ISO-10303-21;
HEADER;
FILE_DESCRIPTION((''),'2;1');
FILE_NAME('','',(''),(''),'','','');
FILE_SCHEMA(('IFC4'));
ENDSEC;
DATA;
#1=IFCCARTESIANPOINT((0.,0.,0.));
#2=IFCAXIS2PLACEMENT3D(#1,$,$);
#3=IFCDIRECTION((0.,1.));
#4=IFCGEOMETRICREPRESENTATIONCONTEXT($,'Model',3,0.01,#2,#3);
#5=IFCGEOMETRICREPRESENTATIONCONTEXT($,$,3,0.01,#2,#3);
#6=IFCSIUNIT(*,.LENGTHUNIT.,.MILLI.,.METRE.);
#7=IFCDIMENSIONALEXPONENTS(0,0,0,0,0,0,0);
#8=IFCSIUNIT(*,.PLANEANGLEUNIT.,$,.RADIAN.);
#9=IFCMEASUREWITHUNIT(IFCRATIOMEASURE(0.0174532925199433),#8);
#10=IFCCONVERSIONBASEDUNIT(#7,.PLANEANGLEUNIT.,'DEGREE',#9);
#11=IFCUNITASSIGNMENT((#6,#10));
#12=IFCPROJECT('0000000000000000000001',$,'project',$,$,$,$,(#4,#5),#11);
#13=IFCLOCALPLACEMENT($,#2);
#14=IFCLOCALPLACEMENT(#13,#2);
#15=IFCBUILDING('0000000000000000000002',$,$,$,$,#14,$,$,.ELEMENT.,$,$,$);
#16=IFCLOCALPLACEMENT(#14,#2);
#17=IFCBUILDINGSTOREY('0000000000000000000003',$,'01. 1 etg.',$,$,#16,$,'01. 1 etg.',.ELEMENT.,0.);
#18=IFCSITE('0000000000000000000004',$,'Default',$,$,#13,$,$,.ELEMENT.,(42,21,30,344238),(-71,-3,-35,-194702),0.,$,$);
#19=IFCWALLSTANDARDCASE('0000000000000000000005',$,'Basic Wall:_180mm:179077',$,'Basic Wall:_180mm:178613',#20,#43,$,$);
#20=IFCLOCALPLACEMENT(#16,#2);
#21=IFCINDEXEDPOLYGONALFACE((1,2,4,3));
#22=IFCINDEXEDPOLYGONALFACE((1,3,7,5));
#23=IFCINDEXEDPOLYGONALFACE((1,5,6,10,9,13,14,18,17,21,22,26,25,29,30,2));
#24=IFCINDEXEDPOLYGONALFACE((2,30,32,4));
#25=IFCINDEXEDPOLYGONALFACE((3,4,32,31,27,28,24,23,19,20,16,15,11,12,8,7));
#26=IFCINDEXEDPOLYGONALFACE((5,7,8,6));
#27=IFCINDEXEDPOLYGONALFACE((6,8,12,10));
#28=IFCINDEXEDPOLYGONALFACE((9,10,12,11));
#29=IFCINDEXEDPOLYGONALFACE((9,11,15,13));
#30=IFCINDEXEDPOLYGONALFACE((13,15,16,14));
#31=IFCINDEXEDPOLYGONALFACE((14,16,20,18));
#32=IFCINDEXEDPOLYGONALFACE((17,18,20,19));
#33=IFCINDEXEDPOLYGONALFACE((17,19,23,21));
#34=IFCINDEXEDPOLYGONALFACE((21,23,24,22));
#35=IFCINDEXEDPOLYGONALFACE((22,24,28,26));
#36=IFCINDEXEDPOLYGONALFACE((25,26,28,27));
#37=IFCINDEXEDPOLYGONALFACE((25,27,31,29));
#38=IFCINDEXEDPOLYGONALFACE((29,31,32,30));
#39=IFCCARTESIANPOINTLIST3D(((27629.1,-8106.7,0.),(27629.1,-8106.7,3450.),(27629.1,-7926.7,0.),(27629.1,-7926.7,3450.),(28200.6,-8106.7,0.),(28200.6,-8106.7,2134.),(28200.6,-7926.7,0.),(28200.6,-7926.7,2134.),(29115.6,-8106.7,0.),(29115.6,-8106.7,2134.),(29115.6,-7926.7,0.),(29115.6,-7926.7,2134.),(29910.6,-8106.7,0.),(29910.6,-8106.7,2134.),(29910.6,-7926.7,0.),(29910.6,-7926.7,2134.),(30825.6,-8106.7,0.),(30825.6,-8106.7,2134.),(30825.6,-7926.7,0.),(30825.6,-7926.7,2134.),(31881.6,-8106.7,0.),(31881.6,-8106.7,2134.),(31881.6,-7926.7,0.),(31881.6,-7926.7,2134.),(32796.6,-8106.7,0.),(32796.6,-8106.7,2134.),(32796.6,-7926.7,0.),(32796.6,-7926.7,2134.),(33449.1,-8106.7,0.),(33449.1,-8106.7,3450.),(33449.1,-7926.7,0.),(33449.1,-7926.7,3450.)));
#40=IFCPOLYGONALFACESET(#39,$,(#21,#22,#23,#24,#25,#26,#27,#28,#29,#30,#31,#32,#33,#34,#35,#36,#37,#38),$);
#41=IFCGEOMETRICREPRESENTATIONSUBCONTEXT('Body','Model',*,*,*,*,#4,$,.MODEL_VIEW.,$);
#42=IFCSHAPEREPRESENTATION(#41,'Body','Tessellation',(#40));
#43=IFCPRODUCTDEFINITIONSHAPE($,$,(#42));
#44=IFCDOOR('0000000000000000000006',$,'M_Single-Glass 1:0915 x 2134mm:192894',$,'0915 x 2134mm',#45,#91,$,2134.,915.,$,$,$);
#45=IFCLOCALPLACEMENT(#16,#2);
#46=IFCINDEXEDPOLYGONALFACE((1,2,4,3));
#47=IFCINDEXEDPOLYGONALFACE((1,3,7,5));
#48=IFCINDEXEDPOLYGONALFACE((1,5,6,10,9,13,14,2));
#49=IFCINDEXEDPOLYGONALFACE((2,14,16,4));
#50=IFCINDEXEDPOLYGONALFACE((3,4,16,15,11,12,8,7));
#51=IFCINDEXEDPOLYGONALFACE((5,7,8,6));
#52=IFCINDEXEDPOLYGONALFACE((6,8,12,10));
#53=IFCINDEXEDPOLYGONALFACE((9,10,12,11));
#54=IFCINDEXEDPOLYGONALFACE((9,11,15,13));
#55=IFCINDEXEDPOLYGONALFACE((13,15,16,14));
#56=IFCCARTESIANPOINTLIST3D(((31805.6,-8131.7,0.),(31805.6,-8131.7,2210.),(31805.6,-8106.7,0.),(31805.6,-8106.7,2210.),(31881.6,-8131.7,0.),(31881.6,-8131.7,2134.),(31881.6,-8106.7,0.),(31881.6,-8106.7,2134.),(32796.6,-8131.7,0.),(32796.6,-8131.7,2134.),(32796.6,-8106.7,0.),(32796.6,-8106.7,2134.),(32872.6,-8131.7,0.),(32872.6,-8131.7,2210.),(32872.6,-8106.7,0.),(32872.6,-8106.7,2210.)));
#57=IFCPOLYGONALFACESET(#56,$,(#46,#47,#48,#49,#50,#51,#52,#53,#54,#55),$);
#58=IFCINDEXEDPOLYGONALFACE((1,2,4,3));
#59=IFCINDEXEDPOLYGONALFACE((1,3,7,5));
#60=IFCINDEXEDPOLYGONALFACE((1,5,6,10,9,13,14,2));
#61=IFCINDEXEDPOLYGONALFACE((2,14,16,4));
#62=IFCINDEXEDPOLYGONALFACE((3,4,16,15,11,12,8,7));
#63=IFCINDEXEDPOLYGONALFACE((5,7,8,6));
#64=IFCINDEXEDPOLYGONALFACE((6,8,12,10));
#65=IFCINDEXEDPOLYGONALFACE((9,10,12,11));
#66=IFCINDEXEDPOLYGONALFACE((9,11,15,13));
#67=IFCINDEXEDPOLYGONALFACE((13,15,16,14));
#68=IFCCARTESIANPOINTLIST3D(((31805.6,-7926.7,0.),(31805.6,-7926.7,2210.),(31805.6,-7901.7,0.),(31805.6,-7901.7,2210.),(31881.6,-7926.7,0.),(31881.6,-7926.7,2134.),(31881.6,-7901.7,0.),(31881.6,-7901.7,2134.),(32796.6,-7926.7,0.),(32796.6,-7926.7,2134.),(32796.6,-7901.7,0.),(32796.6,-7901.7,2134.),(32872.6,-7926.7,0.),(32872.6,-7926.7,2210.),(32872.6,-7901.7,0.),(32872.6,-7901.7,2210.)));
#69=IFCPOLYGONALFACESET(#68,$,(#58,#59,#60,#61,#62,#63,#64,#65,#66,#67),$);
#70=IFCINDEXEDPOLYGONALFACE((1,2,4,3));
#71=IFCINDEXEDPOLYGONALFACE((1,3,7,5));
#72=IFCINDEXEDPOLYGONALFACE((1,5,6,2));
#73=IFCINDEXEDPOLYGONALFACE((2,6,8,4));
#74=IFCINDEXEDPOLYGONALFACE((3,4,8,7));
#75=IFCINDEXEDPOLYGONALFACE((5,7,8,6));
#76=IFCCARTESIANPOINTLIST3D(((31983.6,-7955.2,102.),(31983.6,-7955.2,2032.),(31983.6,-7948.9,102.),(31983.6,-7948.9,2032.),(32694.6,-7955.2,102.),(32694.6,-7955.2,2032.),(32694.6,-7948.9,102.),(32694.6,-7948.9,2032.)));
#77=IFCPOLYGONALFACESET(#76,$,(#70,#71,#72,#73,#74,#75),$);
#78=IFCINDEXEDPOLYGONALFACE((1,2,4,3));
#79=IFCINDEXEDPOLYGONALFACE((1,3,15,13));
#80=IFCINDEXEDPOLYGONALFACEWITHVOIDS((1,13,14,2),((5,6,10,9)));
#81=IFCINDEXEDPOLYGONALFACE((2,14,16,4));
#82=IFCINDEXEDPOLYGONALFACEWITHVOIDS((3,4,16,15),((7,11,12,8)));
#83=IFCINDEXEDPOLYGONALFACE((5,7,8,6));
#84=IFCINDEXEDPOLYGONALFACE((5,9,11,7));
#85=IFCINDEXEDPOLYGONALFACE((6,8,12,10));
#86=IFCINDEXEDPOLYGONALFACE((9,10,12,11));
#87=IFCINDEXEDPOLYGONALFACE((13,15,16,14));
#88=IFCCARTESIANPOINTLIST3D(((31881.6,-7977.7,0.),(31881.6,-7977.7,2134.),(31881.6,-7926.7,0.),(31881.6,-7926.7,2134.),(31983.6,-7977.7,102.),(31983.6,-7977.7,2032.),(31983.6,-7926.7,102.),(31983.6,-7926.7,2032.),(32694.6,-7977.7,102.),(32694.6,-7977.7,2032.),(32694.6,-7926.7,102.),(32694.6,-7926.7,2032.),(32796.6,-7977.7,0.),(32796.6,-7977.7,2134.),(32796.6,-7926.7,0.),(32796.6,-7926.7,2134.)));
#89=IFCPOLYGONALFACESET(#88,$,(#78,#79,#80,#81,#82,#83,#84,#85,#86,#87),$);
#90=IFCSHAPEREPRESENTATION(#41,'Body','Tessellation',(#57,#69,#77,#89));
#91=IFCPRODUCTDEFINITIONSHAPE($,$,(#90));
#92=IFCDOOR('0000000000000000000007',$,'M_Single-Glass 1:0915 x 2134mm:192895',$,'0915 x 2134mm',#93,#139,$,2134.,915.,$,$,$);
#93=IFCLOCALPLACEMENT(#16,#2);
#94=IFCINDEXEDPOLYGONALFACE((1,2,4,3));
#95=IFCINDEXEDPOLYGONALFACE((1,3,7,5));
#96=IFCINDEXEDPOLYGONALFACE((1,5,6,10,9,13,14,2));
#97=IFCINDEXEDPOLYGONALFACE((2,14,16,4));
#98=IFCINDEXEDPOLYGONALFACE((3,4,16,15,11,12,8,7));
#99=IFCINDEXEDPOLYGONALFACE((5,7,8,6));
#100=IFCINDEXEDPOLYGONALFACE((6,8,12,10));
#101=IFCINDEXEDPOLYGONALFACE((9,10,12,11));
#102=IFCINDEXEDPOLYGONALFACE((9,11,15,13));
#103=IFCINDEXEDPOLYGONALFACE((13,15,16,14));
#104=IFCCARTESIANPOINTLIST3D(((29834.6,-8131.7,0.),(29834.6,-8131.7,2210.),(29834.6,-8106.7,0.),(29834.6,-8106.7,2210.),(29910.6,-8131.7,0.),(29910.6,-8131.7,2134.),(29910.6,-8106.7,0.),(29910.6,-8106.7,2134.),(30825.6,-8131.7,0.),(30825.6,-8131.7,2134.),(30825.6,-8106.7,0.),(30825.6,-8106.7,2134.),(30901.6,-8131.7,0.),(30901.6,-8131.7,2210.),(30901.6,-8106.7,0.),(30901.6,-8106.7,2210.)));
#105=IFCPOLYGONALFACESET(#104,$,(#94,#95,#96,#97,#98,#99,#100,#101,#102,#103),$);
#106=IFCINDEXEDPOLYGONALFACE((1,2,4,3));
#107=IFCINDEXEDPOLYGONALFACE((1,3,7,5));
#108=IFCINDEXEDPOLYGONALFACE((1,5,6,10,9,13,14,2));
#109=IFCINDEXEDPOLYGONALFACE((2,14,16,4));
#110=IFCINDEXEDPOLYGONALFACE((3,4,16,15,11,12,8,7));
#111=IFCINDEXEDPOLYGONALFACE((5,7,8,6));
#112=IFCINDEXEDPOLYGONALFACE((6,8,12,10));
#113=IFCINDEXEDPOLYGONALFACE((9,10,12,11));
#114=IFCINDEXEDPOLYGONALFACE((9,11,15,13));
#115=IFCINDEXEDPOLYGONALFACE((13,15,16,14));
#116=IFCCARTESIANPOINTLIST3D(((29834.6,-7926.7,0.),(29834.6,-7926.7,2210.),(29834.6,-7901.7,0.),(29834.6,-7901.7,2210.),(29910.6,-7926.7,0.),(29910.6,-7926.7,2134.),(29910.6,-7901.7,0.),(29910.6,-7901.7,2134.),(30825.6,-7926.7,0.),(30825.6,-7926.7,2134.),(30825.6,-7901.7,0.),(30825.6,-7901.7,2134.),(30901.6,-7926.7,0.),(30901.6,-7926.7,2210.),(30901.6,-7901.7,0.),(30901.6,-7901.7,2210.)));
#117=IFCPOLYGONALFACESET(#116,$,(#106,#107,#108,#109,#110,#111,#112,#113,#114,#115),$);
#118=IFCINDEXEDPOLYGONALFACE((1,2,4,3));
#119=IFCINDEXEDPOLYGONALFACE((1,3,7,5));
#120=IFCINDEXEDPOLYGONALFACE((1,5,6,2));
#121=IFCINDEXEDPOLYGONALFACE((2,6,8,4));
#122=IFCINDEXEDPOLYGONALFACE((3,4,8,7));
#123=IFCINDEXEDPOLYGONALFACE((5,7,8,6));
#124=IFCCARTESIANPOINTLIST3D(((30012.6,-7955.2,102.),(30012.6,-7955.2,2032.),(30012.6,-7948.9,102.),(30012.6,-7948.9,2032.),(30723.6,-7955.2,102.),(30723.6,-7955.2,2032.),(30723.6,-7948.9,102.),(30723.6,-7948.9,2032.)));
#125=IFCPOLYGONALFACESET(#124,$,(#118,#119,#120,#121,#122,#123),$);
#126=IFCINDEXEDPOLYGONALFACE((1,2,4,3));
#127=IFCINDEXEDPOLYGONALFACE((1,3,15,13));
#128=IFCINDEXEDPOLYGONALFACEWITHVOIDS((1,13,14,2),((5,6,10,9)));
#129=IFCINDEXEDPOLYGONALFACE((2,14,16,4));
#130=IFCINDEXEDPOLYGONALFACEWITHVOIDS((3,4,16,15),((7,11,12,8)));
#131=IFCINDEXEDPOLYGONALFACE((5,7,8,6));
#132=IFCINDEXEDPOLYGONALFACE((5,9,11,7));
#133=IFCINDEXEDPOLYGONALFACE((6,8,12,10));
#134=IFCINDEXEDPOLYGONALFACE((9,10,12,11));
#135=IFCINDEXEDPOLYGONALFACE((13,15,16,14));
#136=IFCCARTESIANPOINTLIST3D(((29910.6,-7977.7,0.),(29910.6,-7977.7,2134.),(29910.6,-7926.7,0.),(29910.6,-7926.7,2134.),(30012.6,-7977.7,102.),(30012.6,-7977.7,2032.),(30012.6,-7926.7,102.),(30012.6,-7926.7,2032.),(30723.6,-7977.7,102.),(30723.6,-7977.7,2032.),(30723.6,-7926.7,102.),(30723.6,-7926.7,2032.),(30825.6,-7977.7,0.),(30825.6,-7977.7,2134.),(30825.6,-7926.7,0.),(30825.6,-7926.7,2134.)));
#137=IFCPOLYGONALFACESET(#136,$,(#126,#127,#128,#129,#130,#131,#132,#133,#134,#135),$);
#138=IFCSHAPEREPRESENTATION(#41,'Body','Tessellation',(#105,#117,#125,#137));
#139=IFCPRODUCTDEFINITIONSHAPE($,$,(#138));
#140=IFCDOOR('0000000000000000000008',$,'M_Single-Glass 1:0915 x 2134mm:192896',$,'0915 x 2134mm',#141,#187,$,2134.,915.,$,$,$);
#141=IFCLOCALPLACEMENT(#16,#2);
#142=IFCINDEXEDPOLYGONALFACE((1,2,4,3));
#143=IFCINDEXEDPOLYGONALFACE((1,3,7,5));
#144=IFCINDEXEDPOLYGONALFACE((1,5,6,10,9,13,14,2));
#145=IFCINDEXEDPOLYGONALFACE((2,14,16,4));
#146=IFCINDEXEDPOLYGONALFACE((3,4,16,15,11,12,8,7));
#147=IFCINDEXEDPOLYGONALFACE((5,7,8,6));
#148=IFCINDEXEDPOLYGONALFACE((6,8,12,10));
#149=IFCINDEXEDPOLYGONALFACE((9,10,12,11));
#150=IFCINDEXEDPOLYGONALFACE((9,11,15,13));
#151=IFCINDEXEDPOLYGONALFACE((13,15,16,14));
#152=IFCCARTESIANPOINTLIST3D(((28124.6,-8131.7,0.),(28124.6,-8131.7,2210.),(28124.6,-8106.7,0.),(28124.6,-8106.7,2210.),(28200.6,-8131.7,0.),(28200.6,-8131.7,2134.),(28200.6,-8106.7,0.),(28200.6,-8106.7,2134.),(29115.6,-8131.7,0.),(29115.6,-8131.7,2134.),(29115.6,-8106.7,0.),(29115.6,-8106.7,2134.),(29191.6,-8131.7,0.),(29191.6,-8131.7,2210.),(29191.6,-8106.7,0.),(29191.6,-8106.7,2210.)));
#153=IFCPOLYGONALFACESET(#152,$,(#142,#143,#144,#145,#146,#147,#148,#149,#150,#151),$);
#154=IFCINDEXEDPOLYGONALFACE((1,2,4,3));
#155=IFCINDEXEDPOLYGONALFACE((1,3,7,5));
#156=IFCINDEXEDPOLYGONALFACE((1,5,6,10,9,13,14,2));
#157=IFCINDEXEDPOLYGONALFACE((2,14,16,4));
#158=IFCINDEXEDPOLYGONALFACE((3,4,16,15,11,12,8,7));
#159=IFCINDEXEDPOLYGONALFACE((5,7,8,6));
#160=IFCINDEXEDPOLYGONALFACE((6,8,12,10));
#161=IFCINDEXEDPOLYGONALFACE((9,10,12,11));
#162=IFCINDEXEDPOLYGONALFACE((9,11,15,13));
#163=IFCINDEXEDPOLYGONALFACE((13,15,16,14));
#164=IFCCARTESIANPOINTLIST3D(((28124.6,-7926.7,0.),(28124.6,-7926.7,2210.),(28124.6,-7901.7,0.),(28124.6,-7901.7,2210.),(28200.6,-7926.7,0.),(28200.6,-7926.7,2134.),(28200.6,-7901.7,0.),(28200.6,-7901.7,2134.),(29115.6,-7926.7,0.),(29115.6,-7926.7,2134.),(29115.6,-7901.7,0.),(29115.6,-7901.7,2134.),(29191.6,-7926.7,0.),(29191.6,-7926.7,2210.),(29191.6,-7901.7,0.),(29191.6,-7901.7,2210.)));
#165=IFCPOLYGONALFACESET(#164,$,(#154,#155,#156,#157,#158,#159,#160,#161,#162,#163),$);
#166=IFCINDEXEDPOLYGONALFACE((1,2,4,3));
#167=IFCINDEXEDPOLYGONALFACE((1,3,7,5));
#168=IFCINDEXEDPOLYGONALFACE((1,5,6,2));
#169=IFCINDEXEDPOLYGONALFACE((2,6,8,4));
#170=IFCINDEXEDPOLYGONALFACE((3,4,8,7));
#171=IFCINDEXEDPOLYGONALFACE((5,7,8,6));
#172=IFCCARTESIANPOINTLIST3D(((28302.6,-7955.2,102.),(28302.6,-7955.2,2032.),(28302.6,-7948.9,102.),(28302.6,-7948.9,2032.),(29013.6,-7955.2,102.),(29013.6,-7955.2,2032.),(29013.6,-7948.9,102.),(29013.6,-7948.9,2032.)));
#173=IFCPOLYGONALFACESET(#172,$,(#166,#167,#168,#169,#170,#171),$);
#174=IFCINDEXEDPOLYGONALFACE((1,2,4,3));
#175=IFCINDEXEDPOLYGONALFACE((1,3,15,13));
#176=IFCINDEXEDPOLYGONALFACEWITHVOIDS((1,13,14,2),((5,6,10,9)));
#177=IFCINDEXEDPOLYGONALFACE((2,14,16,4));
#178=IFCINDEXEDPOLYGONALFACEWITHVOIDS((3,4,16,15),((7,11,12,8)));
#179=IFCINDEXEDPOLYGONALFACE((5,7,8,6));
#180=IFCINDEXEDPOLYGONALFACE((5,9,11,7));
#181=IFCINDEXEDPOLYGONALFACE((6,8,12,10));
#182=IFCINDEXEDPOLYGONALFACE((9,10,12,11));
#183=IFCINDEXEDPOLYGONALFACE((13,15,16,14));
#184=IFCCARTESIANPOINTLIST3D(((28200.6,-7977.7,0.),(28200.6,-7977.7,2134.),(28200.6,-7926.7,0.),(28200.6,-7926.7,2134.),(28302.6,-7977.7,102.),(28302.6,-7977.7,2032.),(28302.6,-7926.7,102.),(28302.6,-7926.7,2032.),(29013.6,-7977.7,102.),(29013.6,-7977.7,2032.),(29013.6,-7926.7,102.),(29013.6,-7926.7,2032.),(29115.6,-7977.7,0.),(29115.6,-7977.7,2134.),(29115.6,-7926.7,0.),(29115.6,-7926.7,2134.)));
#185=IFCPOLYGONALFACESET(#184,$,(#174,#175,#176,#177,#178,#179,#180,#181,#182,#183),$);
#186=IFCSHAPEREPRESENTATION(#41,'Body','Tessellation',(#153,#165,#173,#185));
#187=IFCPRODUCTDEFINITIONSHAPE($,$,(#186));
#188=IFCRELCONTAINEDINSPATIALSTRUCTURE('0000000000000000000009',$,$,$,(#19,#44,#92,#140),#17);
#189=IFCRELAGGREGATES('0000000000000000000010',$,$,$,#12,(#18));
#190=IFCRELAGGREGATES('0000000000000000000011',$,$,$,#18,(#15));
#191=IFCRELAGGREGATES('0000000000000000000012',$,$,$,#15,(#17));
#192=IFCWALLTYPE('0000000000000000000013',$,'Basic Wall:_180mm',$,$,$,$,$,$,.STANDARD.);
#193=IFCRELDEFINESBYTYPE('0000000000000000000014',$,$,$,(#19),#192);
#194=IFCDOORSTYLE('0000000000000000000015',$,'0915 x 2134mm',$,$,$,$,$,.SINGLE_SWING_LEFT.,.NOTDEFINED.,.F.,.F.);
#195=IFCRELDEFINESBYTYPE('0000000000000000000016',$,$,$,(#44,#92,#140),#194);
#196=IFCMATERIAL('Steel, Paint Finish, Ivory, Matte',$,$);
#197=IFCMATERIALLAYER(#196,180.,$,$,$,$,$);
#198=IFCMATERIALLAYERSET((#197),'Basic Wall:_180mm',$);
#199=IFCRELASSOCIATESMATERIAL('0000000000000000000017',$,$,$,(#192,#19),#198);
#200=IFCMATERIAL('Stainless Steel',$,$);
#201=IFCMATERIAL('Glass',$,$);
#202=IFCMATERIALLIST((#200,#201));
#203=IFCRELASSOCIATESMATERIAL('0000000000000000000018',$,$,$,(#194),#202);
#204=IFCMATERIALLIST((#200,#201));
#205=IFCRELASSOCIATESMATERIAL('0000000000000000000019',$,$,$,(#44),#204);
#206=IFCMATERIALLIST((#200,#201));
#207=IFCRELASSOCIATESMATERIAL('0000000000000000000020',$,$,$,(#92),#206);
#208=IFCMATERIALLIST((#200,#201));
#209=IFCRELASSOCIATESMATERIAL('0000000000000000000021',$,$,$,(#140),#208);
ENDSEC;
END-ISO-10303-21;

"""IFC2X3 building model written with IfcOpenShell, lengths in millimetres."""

from ifc_helpers import new_model, entity, si_unit, converted_unit, direction, frame, frame_2d, origin, place, context, subcontext, project, spatial, polyline, rectangle, outline, extrude, clip, bounded_halfspace, source, transform, mapped, material, material_list, layer, layer_set, layer_usage, type_object, type_shapes, element, fill, save


model = new_model("IFC2X3")

# Units and contexts
model_context = context("Model", 3, precision=0.01, world=origin(), true_north=direction((0.0, 1.0)))
context_of_model = context(None, 3, precision=0.01, world=origin(), true_north=direction((0.0, 1.0)))
body_context = subcontext(model_context, "Body", "Model", "MODEL_VIEW")
ifc_project = project(units=[si_unit("LENGTHUNIT", "METRE", prefix="MILLI"), converted_unit("PLANEANGLEUNIT", "DEGREE", entity("IfcRatioMeasure", 0.0174532925199433), si_unit("PLANEANGLEUNIT", "RADIAN"), dimensions=[0, 0, 0, 0, 0, 0, 0])], contexts=[model_context, context_of_model])

# Site, building, storey
site_placement = place(None, origin())
site = spatial("IfcSite", under=ifc_project, at=site_placement, Name="Default", CompositionType="ELEMENT", RefLatitude=(42, 21, 30, 344238), RefLongitude=(-71, -3, -35, -194702), RefElevation=0.0)
building_placement = place(site_placement, origin())
building = spatial("IfcBuilding", under=site, at=building_placement, CompositionType="ELEMENT")
storey_placement = place(building_placement, origin())
storey = spatial("IfcBuildingStorey", under=building, at=storey_placement, Name="01. 1 etg.", LongName="01. 1 etg.", CompositionType="ELEMENT", Elevation=0.0)

# Shared definitions
ifc_material_1 = material(Name="Steel, Paint Finish, Ivory, Matte")
ifc_material_2 = material(Name="Stainless Steel")
ifc_material_3 = material(Name="Glass")

# Shared definitions
ifc_layer_1 = layer(ifc_material_1, 180.0)
ifc_layer_set_1 = layer_set([ifc_layer_1], Name="Basic Wall:_180mm")
wall_type_1 = type_object("IfcWallType", Name="Basic Wall:_180mm", PredefinedType="STANDARD", material=ifc_layer_set_1)

# Wall, openings, doors
ifc_layer_usage_1 = layer_usage(ifc_layer_set_1, "AXIS2", "POSITIVE", -90.0)
wall_1_placement = place(storey_placement, frame((27629.1, -8016.7, 0.0)))
wall_1 = element("IfcWallStandardCase", 1, at=wall_1_placement, inside=storey, type_object=wall_type_1, material=ifc_layer_usage_1, Name="Basic Wall:_180mm:179077", ObjectType="Basic Wall:_180mm:178613", context=body_context, shape_type="Clipping", body=[
    clip(extrude(rectangle(XDim=5820.0, YDim=180.0, at=frame_2d((2910.0, 0.0), x_axis=(-1.0, 0.0))), origin(), (0.0, 0.0, 1.0), 3450.0), bounded_halfspace(frame((0.0, -90.0, 3450.0), z_axis=(0.0, 0.0, -1.0), x_axis=(0.0, -1.0, 0.0)), True, frame((0.0, -90.0, 3450.0)), polyline([(0.0, 0.0), (5820.0, 0.0), (5820.0, 180.0), (3600.0, 180.0), (3500.0, 180.0), (1978.0, 180.0), (1878.0, 180.0), (180.0, 180.0), (0.0, 180.0), (0.0, 0.0)]))),
])
opening_1_placement = place(wall_1_placement, frame((4252.5, -90.0, 0.0)))
opening_1 = element("IfcOpeningElement", 2, at=opening_1_placement, cuts=wall_1, ObjectType="Opening", context=body_context, shape_type="SweptSolid", body=[
    extrude(rectangle(XDim=915.0, YDim=2134.0, at=frame_2d((1067.0, 457.5), x_axis=(0.0, -1.0))), frame((0.0, 0.0, 0.0), z_axis=(0.0, 1.0, 0.0), x_axis=(0.0, 0.0, 1.0)), (0.0, 0.0, 1.0), 180.0),
])
opening_2_placement = place(wall_1_placement, frame((2281.5, -90.0, 0.0)))
opening_2 = element("IfcOpeningElement", 3, at=opening_2_placement, cuts=wall_1, ObjectType="Opening", context=body_context, shape_type="SweptSolid", body=[
    extrude(rectangle(XDim=915.0, YDim=2134.0, at=frame_2d((1067.0, 457.5), x_axis=(0.0, -1.0))), frame((0.0, 0.0, 0.0), z_axis=(0.0, 1.0, 0.0), x_axis=(0.0, 0.0, 1.0)), (0.0, 0.0, 1.0), 180.0),
])
opening_3_placement = place(wall_1_placement, frame((571.5, -90.0, 0.0)))
opening_3 = element("IfcOpeningElement", 4, at=opening_3_placement, cuts=wall_1, ObjectType="Opening", context=body_context, shape_type="SweptSolid", body=[
    extrude(rectangle(XDim=915.0, YDim=2134.0, at=frame_2d((1067.0, 457.5), x_axis=(0.0, -1.0))), frame((0.0, 0.0, 0.0), z_axis=(0.0, 1.0, 0.0), x_axis=(0.0, 0.0, 1.0)), (0.0, 0.0, 1.0), 180.0),
])
ifc_material_list_1 = material_list([ifc_material_2, ifc_material_3])
ifc_material_list_2 = material_list([ifc_material_2, ifc_material_3])
door_style_1 = type_object("IfcDoorStyle", Name="0915 x 2134mm", ConstructionType="NOTDEFINED", OperationType="SINGLE_SWING_LEFT", ParameterTakesPrecedence=False, Sizeable=False, material=ifc_material_list_2)
shared_shape_1 = source(origin(), body_context, "Body", "SweptSolid", [
    extrude(outline(polyline([(-457.5, -1048.0), (-457.5, 1086.0), (-533.5, 1086.0), (-533.5, -1124.0), (533.5, -1124.0), (533.5, 1086.0), (457.5, 1086.0), (457.5, -1048.0), (-457.5, -1048.0)])), frame((457.5, 0.0, 1086.0), z_axis=(0.0, 1.0, 0.0), x_axis=(1.0, 0.0, 0.0)), (0.0, 0.0, -1.0), 25.0),
    extrude(outline(polyline([(-457.5, -1048.0), (-457.5, 1086.0), (-533.5, 1086.0), (-533.5, -1124.0), (533.5, -1124.0), (533.5, 1086.0), (457.5, 1086.0), (457.5, -1048.0), (-457.5, -1048.0)])), frame((457.5, 205.0, 1086.0), z_axis=(0.0, 1.0, 0.0), x_axis=(1.0, 0.0, 0.0)), (0.0, 0.0, -1.0), 25.0),
    extrude(rectangle(XDim=711.0, YDim=6.3, at=frame_2d((0.0, 0.0), x_axis=(1.0, 0.0))), frame((457.5, 154.6, 102.0)), (0.0, 0.0, 1.0), 1930.0),
    extrude(outline(polyline([(-1067.0, -457.5), (1067.0, -457.5), (1067.0, 457.5), (-1067.0, 457.5), (-1067.0, -457.5)]), holes=[polyline([(-965.0, 355.5), (965.0, 355.5), (965.0, -355.5), (-965.0, -355.5), (-965.0, 355.5)])]), frame((457.5, 180.0, 1067.0), z_axis=(0.0, -1.0, 0.0), x_axis=(0.0, 0.0, -1.0)), (0.0, 0.0, 1.0), 51.0),
])
type_shapes(door_style_1, [shared_shape_1])
door_1_placement = place(opening_1_placement, origin())
door_1 = element("IfcDoor", 5, at=door_1_placement, inside=storey, type_object=door_style_1, material=ifc_material_list_1, Name="M_Single-Glass 1:0915 x 2134mm:192894", ObjectType="0915 x 2134mm", OverallHeight=2134.0, OverallWidth=915.0, context=body_context, shape_type="MappedRepresentation", body=[
    mapped(shared_shape_1, transform((0.0, 0.0, 0.0), scale=1.0)),
])
fill(opening_1, door_1)
ifc_material_list_3 = material_list([ifc_material_2, ifc_material_3])
door_2_placement = place(opening_2_placement, origin())
door_2 = element("IfcDoor", 6, at=door_2_placement, inside=storey, type_object=door_style_1, material=ifc_material_list_3, Name="M_Single-Glass 1:0915 x 2134mm:192895", ObjectType="0915 x 2134mm", OverallHeight=2134.0, OverallWidth=915.0, context=body_context, shape_type="MappedRepresentation", body=[
    mapped(shared_shape_1, transform((0.0, 0.0, 0.0), scale=1.0)),
])
fill(opening_2, door_2)
ifc_material_list_4 = material_list([ifc_material_2, ifc_material_3])
door_3_placement = place(opening_3_placement, origin())
door_3 = element("IfcDoor", 7, at=door_3_placement, inside=storey, type_object=door_style_1, material=ifc_material_list_4, Name="M_Single-Glass 1:0915 x 2134mm:192896", ObjectType="0915 x 2134mm", OverallHeight=2134.0, OverallWidth=915.0, context=body_context, shape_type="MappedRepresentation", body=[
    mapped(shared_shape_1, transform((0.0, 0.0, 0.0), scale=1.0)),
])
fill(opening_3, door_3)

save(model, "model.ifc")
